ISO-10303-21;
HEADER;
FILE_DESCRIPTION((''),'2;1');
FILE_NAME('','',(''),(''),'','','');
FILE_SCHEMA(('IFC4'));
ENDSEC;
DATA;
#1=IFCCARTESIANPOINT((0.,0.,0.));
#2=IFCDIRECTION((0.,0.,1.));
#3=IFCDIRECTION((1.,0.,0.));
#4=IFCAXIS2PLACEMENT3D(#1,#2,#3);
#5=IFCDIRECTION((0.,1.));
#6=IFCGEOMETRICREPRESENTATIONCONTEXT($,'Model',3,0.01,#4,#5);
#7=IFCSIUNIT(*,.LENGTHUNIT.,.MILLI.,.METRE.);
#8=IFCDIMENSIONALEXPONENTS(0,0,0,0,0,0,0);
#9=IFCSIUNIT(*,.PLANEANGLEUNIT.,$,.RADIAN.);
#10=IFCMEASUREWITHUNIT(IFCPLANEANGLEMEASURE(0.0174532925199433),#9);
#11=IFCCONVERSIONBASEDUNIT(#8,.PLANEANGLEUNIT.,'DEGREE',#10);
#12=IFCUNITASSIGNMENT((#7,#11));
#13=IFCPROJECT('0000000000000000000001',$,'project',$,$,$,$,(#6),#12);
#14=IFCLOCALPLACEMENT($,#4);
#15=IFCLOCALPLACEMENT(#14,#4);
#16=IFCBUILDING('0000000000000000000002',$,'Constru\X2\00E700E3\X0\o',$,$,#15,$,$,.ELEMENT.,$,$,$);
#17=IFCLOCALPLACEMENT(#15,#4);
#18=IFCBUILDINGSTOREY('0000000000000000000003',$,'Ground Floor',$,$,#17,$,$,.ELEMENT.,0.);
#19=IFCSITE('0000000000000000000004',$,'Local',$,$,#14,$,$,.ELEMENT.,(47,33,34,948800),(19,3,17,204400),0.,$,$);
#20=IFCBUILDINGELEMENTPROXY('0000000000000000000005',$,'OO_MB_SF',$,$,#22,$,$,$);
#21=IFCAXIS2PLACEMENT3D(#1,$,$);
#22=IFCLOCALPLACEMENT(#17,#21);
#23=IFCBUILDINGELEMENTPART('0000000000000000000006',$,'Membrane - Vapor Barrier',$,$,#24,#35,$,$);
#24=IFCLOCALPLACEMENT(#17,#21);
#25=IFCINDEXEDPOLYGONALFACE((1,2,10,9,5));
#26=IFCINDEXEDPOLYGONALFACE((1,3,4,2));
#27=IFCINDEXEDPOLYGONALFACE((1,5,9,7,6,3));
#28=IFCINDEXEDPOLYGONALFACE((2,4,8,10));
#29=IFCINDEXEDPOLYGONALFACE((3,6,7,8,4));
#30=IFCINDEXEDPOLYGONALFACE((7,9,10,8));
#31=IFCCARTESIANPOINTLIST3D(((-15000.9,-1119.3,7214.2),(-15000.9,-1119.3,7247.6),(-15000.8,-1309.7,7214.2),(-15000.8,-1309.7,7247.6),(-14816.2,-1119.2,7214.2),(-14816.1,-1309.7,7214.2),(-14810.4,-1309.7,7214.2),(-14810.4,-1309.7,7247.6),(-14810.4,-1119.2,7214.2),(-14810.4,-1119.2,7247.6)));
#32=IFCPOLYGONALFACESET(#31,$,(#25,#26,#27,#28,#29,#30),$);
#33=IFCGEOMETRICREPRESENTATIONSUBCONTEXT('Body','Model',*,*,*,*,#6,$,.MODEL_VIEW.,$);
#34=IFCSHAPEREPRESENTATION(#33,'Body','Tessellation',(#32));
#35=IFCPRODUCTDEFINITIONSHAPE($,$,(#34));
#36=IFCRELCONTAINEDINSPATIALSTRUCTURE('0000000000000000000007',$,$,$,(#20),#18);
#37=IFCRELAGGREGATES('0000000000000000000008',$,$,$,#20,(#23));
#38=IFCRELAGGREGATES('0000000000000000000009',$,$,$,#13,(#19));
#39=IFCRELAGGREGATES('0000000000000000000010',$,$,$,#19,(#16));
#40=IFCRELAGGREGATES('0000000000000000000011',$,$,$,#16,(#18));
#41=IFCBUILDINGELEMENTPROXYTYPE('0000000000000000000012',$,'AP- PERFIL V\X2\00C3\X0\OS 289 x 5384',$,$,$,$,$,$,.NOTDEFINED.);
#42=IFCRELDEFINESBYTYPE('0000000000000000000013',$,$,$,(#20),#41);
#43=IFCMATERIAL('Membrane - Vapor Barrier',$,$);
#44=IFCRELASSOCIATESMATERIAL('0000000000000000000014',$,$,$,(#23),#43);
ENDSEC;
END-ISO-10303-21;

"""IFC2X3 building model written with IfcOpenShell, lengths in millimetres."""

from ifc_helpers import new_model, entity, si_unit, converted_unit, direction, frame, origin_with_axes, place, context, subcontext, project, spatial, polyline, outline, extrude, material, type_object, element, aggregate, save


model = new_model("IFC2X3")

# Units and contexts
model_context = context("Model", 3, precision=0.01, world=origin_with_axes(), true_north=direction((0.0, 1.0)))
body_context = subcontext(model_context, "Body", "Model", "MODEL_VIEW")
ifc_project = project(units=[si_unit("LENGTHUNIT", "METRE", prefix="MILLI"), converted_unit("PLANEANGLEUNIT", "DEGREE", entity("IfcPlaneAngleMeasure", 0.0174532925199433), si_unit("PLANEANGLEUNIT", "RADIAN"), dimensions=[0, 0, 0, 0, 0, 0, 0])], contexts=[model_context])

# Site, building, storey
site_placement = place(None, origin_with_axes())
site = spatial("IfcSite", under=ifc_project, at=site_placement, Name="Local", CompositionType="ELEMENT", RefLatitude=(47, 33, 34, 948800), RefLongitude=(19, 3, 17, 204400), RefElevation=0.0)
building_placement = place(site_placement, origin_with_axes())
building = spatial("IfcBuilding", under=site, at=building_placement, Name="Construção", CompositionType="ELEMENT")
storey_placement = place(building_placement, origin_with_axes())
storey = spatial("IfcBuildingStorey", under=building, at=storey_placement, Name="Ground Floor", CompositionType="ELEMENT", Elevation=0.0)

# Building element proxy
building_element_proxy_type = type_object("IfcBuildingElementProxyType", Name="AP- PERFIL VÃOS 289 x 5384", PredefinedType="NOTDEFINED")
ifc_material = material(Name="Membrane - Vapor Barrier")
proxy_1_placement = place(storey_placement, frame((-15000.9, -1119.3, 7247.6), z_axis=(0.0, 0.0, 1.0), x_axis=(-1.0, -0.000322, 0.0)))
proxy_1 = element("IfcBuildingElementProxy", 1, at=proxy_1_placement, inside=storey, type_object=building_element_proxy_type, Name="OO_MB_SF")

# Building element part
building_element_part_1_placement = place(proxy_1_placement, origin_with_axes())
building_element_part_1 = element("IfcBuildingElementPart", 2, at=building_element_part_1_placement, material=ifc_material, Name="Membrane - Vapor Barrier", context=body_context, shape_type="SweptSolid", body=[
    extrude(outline(polyline([(190.4, 0.0), (0.0, 0.0), (0.0, -33.3), (184.7, -33.3), (190.4, -33.3), (190.4, 0.0)])), frame((0.0, 190.4, 0.0), z_axis=(0.0, 1.0, 0.0), x_axis=(-1.0, 0.0, 0.0)), (0.0, 0.0, -1.0), 190.4),
])
aggregate(proxy_1, [building_element_part_1])

save(model, "model.ifc")
